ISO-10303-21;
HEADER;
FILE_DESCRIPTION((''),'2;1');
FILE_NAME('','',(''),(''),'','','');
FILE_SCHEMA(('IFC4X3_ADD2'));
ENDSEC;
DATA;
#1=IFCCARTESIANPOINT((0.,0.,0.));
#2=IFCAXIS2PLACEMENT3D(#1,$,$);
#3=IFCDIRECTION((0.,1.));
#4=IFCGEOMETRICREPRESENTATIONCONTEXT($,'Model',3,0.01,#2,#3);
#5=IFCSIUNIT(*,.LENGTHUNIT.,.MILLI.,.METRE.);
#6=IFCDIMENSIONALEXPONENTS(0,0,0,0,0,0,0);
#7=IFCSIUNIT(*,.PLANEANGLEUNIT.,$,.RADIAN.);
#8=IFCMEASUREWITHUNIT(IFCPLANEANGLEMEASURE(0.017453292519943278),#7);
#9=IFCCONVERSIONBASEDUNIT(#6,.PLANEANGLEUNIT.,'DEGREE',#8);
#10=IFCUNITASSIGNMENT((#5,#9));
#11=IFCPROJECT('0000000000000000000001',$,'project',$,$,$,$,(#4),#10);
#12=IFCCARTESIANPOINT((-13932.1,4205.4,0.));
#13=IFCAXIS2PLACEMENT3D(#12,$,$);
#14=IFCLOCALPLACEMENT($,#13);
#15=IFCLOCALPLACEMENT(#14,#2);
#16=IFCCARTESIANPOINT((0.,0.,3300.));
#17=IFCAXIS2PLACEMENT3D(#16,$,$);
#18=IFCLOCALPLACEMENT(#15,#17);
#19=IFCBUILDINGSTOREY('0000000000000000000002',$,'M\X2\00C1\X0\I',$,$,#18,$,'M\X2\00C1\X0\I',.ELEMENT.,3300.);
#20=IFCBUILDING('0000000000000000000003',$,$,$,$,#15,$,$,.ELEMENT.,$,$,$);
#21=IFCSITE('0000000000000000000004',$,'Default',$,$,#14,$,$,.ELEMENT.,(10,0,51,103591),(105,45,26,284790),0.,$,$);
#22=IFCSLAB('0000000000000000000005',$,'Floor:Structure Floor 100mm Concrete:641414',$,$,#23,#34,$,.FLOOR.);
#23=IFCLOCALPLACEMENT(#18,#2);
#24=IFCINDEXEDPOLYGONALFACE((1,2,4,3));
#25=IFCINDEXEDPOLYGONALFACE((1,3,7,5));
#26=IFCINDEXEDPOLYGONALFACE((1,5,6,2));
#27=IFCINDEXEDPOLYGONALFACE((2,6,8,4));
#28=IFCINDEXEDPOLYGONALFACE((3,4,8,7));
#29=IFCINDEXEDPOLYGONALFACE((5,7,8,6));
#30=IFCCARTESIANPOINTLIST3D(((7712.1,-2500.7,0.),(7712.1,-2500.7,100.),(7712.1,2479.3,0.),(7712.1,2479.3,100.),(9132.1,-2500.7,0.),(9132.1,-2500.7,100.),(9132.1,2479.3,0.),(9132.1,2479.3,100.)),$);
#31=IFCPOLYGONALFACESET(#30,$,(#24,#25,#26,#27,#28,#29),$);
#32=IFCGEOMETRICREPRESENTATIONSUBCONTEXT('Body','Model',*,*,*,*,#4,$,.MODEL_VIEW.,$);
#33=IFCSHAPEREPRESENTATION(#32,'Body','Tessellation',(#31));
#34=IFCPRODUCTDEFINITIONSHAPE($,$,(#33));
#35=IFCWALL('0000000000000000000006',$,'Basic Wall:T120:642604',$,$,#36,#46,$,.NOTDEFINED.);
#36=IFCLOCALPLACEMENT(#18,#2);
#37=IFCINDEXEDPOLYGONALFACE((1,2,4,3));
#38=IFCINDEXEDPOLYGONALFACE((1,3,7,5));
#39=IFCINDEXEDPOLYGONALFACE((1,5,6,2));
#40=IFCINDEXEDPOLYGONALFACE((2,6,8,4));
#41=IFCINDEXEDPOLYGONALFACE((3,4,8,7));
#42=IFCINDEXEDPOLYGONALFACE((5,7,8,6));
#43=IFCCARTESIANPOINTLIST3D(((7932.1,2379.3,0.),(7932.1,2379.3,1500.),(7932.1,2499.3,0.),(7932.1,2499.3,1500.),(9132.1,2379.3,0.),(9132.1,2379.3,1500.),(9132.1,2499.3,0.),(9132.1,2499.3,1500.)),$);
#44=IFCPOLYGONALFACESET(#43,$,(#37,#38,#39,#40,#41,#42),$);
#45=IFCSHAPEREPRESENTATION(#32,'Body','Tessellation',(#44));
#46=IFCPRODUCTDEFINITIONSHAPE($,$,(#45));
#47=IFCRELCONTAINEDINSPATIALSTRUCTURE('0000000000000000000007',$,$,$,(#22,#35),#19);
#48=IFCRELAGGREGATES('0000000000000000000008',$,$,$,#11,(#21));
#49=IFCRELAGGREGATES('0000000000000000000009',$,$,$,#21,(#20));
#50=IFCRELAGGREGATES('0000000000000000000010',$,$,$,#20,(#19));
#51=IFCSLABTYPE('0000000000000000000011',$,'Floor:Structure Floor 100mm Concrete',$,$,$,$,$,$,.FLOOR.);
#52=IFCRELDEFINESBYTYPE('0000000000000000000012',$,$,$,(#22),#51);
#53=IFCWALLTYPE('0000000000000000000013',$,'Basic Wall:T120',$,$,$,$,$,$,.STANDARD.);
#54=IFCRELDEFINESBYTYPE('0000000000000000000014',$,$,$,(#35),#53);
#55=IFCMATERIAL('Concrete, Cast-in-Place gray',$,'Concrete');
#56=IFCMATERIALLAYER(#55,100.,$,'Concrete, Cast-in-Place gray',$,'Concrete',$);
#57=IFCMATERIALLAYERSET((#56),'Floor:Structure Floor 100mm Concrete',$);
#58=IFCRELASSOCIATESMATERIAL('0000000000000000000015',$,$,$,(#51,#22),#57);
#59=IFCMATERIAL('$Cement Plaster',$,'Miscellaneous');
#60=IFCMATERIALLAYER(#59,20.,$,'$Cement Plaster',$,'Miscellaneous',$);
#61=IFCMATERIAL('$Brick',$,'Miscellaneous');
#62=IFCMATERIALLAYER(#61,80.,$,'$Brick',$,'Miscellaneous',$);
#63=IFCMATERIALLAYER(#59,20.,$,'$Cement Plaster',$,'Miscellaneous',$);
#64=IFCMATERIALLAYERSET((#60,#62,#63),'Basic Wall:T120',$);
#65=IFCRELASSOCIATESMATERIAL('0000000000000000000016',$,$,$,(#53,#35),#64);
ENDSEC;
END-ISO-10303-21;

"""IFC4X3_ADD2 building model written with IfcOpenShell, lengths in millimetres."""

from ifc_helpers import new_model, entity, si_unit, converted_unit, direction, frame, frame_2d, origin, place, context, subcontext, project, spatial, rectangle, extrude, material, layer, layer_set, layer_usage, type_object, element, save


model = new_model("IFC4X3_ADD2")

# Units and contexts
model_context = context("Model", 3, precision=0.01, world=origin(), true_north=direction((0.0, 1.0)))
body_context = subcontext(model_context, "Body", "Model", "MODEL_VIEW")
ifc_project = project(units=[si_unit("LENGTHUNIT", "METRE", prefix="MILLI"), converted_unit("PLANEANGLEUNIT", "DEGREE", entity("IfcPlaneAngleMeasure", 0.017453292519943278), si_unit("PLANEANGLEUNIT", "RADIAN"), dimensions=[0, 0, 0, 0, 0, 0, 0])], contexts=[model_context])

# Site, building, storey
site_placement = place(None, frame((-13932.1, 4205.4, 0.0)))
site = spatial("IfcSite", under=ifc_project, at=site_placement, Name="Default", CompositionType="ELEMENT", RefLatitude=(10, 0, 51, 103591), RefLongitude=(105, 45, 26, 284790), RefElevation=0.0)
building_placement = place(site_placement, origin())
building = spatial("IfcBuilding", under=site, at=building_placement, CompositionType="ELEMENT")
storey_placement = place(building_placement, frame((0.0, 0.0, 3300.0)))
storey = spatial("IfcBuildingStorey", under=building, at=storey_placement, Name="MÁI", LongName="MÁI", CompositionType="ELEMENT", Elevation=3300.0)

# Slab
ifc_material_1 = material(Name="Concrete, Cast-in-Place gray", Category="Concrete")
ifc_layer_1 = layer(ifc_material_1, 100.0, Name="Concrete, Cast-in-Place gray", Category="Concrete")
ifc_layer_set_1 = layer_set([ifc_layer_1], Name="Floor:Structure Floor 100mm Concrete")
ifc_layer_usage = layer_usage(ifc_layer_set_1, "AXIS3", "POSITIVE", 0.0)
slab_type = type_object("IfcSlabType", Name="Floor:Structure Floor 100mm Concrete", PredefinedType="FLOOR", material=ifc_layer_set_1)
slab_placement = place(storey_placement, origin())
element("IfcSlab", 1, at=slab_placement, inside=storey, type_object=slab_type, material=ifc_layer_usage, Name="Floor:Structure Floor 100mm Concrete:641414", PredefinedType="FLOOR", context=body_context, shape_type="SweptSolid", body=[
    extrude(rectangle(XDim=4980.0, YDim=1420.0, at=frame_2d((0.0, 0.0), x_axis=(1.0, 0.0))), frame((8422.1, -10.7, 100.0), z_axis=(0.0, 0.0, -1.0), x_axis=(0.0, 1.0, 0.0)), (0.0, 0.0, 1.0), 100.0),
])

# Wall
ifc_material_2 = material(Name="$Cement Plaster", Category="Miscellaneous")
ifc_layer_2 = layer(ifc_material_2, 20.0, Name="$Cement Plaster", Category="Miscellaneous")
ifc_material_3 = material(Name="$Brick", Category="Miscellaneous")
ifc_layer_3 = layer(ifc_material_3, 80.0, Name="$Brick", Category="Miscellaneous")
ifc_layer_4 = layer(ifc_material_2, 20.0, Name="$Cement Plaster", Category="Miscellaneous")
ifc_layer_set_2 = layer_set([ifc_layer_2, ifc_layer_3, ifc_layer_4], Name="Basic Wall:T120")
wall_type = type_object("IfcWallType", Name="Basic Wall:T120", PredefinedType="STANDARD", material=ifc_layer_set_2)
wall_1_placement = place(storey_placement, frame((7932.1, 2439.3, 0.0)))
element("IfcWall", 2, at=wall_1_placement, inside=storey, type_object=wall_type, material=ifc_layer_set_2, Name="Basic Wall:T120:642604", PredefinedType="NOTDEFINED", context=body_context, shape_type="SweptSolid", body=[
    extrude(rectangle(XDim=1200.0, YDim=120.0, at=frame_2d((600.0, 0.0), x_axis=(-1.0, 0.0))), origin(), (0.0, 0.0, 1.0), 1500.0),
])

save(model, "model.ifc")
